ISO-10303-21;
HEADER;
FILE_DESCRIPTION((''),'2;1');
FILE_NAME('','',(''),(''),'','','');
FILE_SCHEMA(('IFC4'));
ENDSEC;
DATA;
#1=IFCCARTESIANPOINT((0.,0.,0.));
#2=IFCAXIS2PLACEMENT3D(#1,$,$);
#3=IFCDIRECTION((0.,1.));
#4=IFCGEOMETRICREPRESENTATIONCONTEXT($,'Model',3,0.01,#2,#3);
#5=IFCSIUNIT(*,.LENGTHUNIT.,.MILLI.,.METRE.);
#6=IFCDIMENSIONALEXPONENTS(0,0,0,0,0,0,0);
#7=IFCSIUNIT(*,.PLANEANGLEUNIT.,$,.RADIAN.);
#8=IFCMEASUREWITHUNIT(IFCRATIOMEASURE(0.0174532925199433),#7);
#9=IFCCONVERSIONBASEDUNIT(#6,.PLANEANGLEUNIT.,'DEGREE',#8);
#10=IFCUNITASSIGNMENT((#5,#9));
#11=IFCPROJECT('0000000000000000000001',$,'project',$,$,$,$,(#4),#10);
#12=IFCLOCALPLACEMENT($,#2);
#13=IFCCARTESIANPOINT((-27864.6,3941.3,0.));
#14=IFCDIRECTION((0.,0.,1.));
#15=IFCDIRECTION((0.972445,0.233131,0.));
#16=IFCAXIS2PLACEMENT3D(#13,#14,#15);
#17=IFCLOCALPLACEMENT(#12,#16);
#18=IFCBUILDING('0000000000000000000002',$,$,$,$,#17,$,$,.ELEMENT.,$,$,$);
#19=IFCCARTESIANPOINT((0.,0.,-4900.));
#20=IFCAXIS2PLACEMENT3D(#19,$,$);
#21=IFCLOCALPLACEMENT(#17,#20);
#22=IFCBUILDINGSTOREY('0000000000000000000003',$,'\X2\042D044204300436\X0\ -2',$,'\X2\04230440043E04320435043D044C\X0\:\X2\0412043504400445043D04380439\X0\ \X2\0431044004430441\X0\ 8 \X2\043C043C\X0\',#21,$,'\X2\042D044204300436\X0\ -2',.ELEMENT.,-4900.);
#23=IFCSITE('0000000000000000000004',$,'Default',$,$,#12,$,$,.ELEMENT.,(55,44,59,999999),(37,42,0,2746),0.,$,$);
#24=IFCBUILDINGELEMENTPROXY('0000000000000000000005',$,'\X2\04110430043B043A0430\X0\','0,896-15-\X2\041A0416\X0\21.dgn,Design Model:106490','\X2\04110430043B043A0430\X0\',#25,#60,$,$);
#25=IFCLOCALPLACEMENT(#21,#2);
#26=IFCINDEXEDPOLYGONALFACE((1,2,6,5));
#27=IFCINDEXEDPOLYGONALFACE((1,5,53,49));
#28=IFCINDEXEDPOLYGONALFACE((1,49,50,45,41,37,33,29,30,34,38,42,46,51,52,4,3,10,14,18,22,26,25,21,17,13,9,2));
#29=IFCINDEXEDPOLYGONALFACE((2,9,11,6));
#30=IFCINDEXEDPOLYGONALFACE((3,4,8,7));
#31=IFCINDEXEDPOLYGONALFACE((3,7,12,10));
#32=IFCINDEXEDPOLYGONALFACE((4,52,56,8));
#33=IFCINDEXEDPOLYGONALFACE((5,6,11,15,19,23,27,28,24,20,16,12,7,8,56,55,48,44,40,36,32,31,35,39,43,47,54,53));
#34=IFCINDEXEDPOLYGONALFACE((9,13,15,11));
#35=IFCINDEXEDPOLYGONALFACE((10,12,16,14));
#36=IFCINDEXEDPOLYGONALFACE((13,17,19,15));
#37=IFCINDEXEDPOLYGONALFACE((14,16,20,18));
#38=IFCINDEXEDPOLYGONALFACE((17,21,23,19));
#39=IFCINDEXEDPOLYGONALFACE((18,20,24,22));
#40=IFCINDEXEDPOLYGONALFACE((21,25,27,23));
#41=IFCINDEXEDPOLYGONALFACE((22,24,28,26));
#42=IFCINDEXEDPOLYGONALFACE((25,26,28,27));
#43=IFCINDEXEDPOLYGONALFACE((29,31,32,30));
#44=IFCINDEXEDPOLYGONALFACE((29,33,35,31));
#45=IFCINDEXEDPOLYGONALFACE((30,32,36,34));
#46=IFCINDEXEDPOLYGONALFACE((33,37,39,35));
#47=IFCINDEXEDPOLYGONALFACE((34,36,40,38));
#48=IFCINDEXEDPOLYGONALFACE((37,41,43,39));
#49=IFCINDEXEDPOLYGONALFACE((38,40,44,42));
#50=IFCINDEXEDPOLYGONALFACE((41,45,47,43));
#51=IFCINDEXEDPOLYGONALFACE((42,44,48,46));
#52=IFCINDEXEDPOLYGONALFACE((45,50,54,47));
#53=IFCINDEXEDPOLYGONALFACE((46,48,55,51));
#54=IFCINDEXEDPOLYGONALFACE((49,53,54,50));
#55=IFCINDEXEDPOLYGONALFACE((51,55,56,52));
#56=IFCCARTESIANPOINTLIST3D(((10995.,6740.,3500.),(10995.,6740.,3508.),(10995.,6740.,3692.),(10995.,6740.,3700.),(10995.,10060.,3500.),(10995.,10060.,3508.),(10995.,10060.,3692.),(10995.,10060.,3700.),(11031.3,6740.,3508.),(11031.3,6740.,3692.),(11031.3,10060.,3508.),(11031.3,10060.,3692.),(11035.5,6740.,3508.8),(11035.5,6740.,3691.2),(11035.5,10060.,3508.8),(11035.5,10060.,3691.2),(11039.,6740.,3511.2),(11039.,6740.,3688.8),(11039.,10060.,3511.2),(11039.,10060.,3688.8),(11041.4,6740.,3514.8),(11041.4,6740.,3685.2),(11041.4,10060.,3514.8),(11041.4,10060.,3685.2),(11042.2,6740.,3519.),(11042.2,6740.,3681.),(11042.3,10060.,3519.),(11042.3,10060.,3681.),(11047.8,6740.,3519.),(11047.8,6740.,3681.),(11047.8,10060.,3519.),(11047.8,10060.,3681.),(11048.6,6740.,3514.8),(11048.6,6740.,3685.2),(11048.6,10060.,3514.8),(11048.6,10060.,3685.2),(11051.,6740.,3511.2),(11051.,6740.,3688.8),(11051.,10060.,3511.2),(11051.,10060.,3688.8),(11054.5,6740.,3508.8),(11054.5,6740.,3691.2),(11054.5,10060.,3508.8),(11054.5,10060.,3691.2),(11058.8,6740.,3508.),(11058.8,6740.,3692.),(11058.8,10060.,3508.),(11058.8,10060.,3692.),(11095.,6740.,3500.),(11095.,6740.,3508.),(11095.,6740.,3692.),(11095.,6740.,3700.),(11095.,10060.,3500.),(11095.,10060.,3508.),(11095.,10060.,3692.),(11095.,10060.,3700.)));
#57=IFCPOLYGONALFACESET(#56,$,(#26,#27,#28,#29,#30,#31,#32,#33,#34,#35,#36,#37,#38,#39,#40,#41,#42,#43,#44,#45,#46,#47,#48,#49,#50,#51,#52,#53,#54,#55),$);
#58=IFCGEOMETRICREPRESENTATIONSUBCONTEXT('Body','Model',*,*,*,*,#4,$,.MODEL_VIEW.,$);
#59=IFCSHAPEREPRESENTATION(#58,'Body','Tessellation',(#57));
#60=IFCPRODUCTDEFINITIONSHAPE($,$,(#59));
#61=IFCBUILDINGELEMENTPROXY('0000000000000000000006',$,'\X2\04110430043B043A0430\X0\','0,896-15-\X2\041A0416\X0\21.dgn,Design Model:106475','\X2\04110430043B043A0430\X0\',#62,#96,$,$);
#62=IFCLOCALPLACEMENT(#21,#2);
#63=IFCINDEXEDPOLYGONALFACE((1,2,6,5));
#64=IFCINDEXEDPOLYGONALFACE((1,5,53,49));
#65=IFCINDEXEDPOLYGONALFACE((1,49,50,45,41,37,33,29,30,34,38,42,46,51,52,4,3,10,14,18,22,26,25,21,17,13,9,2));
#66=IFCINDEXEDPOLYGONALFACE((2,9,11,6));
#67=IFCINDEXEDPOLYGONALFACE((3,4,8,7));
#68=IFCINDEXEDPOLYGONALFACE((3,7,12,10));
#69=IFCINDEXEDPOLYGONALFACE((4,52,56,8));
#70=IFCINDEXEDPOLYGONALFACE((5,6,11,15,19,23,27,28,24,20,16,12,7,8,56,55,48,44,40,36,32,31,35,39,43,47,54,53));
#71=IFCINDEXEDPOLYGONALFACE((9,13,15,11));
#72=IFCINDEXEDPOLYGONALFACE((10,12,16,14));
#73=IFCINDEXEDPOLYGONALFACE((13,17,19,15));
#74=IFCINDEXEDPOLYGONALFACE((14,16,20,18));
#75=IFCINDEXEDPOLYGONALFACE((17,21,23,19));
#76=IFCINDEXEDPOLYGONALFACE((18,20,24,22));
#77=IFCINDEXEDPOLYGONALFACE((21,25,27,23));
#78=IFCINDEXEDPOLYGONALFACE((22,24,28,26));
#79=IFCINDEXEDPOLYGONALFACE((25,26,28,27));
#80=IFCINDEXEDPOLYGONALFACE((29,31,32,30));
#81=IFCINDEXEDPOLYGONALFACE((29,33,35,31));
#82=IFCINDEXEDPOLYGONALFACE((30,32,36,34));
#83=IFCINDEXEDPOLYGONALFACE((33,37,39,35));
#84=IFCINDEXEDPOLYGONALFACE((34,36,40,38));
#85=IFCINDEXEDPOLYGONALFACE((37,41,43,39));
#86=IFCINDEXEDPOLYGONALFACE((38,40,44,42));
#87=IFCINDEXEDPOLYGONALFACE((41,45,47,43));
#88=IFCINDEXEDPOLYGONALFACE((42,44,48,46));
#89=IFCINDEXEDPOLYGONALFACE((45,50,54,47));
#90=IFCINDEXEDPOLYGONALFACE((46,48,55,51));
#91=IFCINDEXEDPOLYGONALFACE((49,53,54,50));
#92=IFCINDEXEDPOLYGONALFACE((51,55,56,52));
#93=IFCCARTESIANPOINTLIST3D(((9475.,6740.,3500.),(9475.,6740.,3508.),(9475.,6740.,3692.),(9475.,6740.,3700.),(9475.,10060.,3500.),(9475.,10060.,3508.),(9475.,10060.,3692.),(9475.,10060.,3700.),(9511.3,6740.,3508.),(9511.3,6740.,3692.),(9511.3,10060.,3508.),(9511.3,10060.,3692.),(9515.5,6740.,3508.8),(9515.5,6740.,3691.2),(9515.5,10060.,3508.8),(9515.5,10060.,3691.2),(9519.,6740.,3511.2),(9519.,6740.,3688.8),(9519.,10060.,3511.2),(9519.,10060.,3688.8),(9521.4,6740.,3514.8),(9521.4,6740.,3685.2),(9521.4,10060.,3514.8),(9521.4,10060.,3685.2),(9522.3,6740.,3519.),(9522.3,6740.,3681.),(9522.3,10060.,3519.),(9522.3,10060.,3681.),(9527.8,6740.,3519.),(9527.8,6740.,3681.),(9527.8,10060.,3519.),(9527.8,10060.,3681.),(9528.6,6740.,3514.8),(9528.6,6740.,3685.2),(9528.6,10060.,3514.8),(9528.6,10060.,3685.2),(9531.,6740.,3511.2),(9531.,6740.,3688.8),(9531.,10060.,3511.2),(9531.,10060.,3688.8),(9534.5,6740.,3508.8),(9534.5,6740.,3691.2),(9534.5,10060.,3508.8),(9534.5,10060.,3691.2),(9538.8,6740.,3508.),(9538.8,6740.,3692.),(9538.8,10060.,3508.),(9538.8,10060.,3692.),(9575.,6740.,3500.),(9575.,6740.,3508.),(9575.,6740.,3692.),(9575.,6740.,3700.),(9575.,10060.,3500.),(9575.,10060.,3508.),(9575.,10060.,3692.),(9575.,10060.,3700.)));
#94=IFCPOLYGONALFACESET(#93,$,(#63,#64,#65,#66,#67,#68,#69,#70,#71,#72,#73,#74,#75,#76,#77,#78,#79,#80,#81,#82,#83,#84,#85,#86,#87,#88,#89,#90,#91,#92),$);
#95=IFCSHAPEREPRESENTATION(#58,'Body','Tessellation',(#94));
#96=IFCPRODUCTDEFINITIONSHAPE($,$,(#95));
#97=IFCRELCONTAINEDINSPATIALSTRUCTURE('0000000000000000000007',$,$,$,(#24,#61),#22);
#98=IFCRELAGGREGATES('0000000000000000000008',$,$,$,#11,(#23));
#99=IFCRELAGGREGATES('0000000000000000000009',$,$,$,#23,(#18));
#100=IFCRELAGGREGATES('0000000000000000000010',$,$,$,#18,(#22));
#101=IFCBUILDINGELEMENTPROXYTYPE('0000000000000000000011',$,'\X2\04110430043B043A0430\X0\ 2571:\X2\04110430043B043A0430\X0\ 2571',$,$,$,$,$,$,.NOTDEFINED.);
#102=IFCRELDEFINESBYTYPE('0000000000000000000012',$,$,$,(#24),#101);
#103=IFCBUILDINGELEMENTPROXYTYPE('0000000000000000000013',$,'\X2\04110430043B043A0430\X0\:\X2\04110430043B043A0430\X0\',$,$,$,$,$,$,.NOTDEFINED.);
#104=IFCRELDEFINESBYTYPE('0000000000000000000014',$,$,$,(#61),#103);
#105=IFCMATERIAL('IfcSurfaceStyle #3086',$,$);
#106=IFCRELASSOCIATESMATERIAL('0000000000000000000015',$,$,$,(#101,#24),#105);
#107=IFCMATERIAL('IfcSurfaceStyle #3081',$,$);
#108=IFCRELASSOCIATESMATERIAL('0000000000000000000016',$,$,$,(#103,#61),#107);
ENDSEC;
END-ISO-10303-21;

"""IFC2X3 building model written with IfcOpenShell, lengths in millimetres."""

from ifc_helpers import new_model, entity, si_unit, converted_unit, direction, frame, origin, place, context, subcontext, project, spatial, polyline, outline, extrude, source, transform, mapped, material, type_object, type_shapes, element, save


model = new_model("IFC2X3")

# Units and contexts
model_context = context("Model", 3, precision=0.01, world=origin(), true_north=direction((0.0, 1.0)))
body_context = subcontext(model_context, "Body", "Model", "MODEL_VIEW")
ifc_project = project(units=[si_unit("LENGTHUNIT", "METRE", prefix="MILLI"), converted_unit("PLANEANGLEUNIT", "DEGREE", entity("IfcRatioMeasure", 0.0174532925199433), si_unit("PLANEANGLEUNIT", "RADIAN"), dimensions=[0, 0, 0, 0, 0, 0, 0])], contexts=[model_context])

# Site, building, storey
site_placement = place(None, origin())
site = spatial("IfcSite", under=ifc_project, at=site_placement, Name="Default", CompositionType="ELEMENT", RefLatitude=(55, 44, 59, 999999), RefLongitude=(37, 42, 0, 2746), RefElevation=0.0)
building_placement = place(site_placement, frame((-27864.6, 3941.3, 0.0), z_axis=(0.0, 0.0, 1.0), x_axis=(0.972445, 0.233131, 0.0)))
building = spatial("IfcBuilding", under=site, at=building_placement, CompositionType="ELEMENT")
storey_placement = place(building_placement, frame((0.0, 0.0, -4900.0)))
storey = spatial("IfcBuildingStorey", under=building, at=storey_placement, Name="Этаж -2", ObjectType="Уровень:Верхний брус 8 мм", LongName="Этаж -2", CompositionType="ELEMENT", Elevation=-4900.0)

# Building element proxies
placement = place(storey_placement, frame((0.0, 0.0, 4900.0)))
ifc_material_1 = material(Name="IfcSurfaceStyle #3086")
building_element_proxy_type_1 = type_object("IfcBuildingElementProxyType", Name="Балка 2571:Балка 2571", PredefinedType="NOTDEFINED", material=ifc_material_1)
shared_shape_1 = source(origin(), body_context, "Body", "SweptSolid", [
    extrude(outline(polyline([(92.0, -50.0), (100.0, -50.0), (100.0, 50.0), (92.0, 50.0), (92.0, 13.8), (91.2, 9.5), (88.8, 6.0), (85.2, 3.6), (81.0, 2.8), (-81.0, 2.8), (-85.2, 3.6), (-88.8, 6.0), (-91.2, 9.5), (-92.0, 13.8), (-92.0, 50.0), (-100.0, 50.0), (-100.0, -50.0), (-92.0, -50.0), (-92.0, -13.8), (-91.2, -9.5), (-88.8, -6.0), (-85.2, -3.6), (-81.0, -2.8), (81.0, -2.8), (85.2, -3.6), (88.8, -6.0), (91.2, -9.5), (92.0, -13.8), (92.0, -50.0)])), frame((11045.0, 6740.0, -1300.0), z_axis=(0.0, 1.0, 0.0), x_axis=(0.0, 0.0, -1.0)), (0.0, 0.0, 1.0), 3320.0),
])
type_shapes(building_element_proxy_type_1, [shared_shape_1])
element("IfcBuildingElementProxy", 1, at=placement, inside=storey, type_object=building_element_proxy_type_1, material=ifc_material_1, Name="Балка", Description="0,896-15-КЖ21.dgn,Design Model:106490", ObjectType="Балка", context=body_context, shape_type="MappedRepresentation", body=[
    mapped(shared_shape_1, transform((0.0, 0.0, 0.0), scale=1.0)),
])
ifc_material_2 = material(Name="IfcSurfaceStyle #3081")
building_element_proxy_type_2 = type_object("IfcBuildingElementProxyType", Name="Балка:Балка", PredefinedType="NOTDEFINED", material=ifc_material_2)
shared_shape_2 = source(origin(), body_context, "Body", "SweptSolid", [
    extrude(outline(polyline([(92.0, -50.0), (100.0, -50.0), (100.0, 50.0), (92.0, 50.0), (92.0, 13.8), (91.2, 9.5), (88.8, 6.0), (85.2, 3.6), (81.0, 2.8), (-81.0, 2.8), (-85.2, 3.6), (-88.8, 6.0), (-91.2, 9.5), (-92.0, 13.8), (-92.0, 50.0), (-100.0, 50.0), (-100.0, -50.0), (-92.0, -50.0), (-92.0, -13.8), (-91.2, -9.5), (-88.8, -6.0), (-85.2, -3.6), (-81.0, -2.8), (81.0, -2.8), (85.2, -3.6), (88.8, -6.0), (91.2, -9.5), (92.0, -13.8), (92.0, -50.0)])), frame((9525.0, 6740.0, -1300.0), z_axis=(0.0, 1.0, 0.0), x_axis=(0.0, 0.0, -1.0)), (0.0, 0.0, 1.0), 3320.0),
])
type_shapes(building_element_proxy_type_2, [shared_shape_2])
element("IfcBuildingElementProxy", 2, at=placement, inside=storey, type_object=building_element_proxy_type_2, material=ifc_material_2, Name="Балка", Description="0,896-15-КЖ21.dgn,Design Model:106475", ObjectType="Балка", context=body_context, shape_type="MappedRepresentation", body=[
    mapped(shared_shape_2, transform((0.0, 0.0, 0.0), scale=1.0)),
])

save(model, "model.ifc")
